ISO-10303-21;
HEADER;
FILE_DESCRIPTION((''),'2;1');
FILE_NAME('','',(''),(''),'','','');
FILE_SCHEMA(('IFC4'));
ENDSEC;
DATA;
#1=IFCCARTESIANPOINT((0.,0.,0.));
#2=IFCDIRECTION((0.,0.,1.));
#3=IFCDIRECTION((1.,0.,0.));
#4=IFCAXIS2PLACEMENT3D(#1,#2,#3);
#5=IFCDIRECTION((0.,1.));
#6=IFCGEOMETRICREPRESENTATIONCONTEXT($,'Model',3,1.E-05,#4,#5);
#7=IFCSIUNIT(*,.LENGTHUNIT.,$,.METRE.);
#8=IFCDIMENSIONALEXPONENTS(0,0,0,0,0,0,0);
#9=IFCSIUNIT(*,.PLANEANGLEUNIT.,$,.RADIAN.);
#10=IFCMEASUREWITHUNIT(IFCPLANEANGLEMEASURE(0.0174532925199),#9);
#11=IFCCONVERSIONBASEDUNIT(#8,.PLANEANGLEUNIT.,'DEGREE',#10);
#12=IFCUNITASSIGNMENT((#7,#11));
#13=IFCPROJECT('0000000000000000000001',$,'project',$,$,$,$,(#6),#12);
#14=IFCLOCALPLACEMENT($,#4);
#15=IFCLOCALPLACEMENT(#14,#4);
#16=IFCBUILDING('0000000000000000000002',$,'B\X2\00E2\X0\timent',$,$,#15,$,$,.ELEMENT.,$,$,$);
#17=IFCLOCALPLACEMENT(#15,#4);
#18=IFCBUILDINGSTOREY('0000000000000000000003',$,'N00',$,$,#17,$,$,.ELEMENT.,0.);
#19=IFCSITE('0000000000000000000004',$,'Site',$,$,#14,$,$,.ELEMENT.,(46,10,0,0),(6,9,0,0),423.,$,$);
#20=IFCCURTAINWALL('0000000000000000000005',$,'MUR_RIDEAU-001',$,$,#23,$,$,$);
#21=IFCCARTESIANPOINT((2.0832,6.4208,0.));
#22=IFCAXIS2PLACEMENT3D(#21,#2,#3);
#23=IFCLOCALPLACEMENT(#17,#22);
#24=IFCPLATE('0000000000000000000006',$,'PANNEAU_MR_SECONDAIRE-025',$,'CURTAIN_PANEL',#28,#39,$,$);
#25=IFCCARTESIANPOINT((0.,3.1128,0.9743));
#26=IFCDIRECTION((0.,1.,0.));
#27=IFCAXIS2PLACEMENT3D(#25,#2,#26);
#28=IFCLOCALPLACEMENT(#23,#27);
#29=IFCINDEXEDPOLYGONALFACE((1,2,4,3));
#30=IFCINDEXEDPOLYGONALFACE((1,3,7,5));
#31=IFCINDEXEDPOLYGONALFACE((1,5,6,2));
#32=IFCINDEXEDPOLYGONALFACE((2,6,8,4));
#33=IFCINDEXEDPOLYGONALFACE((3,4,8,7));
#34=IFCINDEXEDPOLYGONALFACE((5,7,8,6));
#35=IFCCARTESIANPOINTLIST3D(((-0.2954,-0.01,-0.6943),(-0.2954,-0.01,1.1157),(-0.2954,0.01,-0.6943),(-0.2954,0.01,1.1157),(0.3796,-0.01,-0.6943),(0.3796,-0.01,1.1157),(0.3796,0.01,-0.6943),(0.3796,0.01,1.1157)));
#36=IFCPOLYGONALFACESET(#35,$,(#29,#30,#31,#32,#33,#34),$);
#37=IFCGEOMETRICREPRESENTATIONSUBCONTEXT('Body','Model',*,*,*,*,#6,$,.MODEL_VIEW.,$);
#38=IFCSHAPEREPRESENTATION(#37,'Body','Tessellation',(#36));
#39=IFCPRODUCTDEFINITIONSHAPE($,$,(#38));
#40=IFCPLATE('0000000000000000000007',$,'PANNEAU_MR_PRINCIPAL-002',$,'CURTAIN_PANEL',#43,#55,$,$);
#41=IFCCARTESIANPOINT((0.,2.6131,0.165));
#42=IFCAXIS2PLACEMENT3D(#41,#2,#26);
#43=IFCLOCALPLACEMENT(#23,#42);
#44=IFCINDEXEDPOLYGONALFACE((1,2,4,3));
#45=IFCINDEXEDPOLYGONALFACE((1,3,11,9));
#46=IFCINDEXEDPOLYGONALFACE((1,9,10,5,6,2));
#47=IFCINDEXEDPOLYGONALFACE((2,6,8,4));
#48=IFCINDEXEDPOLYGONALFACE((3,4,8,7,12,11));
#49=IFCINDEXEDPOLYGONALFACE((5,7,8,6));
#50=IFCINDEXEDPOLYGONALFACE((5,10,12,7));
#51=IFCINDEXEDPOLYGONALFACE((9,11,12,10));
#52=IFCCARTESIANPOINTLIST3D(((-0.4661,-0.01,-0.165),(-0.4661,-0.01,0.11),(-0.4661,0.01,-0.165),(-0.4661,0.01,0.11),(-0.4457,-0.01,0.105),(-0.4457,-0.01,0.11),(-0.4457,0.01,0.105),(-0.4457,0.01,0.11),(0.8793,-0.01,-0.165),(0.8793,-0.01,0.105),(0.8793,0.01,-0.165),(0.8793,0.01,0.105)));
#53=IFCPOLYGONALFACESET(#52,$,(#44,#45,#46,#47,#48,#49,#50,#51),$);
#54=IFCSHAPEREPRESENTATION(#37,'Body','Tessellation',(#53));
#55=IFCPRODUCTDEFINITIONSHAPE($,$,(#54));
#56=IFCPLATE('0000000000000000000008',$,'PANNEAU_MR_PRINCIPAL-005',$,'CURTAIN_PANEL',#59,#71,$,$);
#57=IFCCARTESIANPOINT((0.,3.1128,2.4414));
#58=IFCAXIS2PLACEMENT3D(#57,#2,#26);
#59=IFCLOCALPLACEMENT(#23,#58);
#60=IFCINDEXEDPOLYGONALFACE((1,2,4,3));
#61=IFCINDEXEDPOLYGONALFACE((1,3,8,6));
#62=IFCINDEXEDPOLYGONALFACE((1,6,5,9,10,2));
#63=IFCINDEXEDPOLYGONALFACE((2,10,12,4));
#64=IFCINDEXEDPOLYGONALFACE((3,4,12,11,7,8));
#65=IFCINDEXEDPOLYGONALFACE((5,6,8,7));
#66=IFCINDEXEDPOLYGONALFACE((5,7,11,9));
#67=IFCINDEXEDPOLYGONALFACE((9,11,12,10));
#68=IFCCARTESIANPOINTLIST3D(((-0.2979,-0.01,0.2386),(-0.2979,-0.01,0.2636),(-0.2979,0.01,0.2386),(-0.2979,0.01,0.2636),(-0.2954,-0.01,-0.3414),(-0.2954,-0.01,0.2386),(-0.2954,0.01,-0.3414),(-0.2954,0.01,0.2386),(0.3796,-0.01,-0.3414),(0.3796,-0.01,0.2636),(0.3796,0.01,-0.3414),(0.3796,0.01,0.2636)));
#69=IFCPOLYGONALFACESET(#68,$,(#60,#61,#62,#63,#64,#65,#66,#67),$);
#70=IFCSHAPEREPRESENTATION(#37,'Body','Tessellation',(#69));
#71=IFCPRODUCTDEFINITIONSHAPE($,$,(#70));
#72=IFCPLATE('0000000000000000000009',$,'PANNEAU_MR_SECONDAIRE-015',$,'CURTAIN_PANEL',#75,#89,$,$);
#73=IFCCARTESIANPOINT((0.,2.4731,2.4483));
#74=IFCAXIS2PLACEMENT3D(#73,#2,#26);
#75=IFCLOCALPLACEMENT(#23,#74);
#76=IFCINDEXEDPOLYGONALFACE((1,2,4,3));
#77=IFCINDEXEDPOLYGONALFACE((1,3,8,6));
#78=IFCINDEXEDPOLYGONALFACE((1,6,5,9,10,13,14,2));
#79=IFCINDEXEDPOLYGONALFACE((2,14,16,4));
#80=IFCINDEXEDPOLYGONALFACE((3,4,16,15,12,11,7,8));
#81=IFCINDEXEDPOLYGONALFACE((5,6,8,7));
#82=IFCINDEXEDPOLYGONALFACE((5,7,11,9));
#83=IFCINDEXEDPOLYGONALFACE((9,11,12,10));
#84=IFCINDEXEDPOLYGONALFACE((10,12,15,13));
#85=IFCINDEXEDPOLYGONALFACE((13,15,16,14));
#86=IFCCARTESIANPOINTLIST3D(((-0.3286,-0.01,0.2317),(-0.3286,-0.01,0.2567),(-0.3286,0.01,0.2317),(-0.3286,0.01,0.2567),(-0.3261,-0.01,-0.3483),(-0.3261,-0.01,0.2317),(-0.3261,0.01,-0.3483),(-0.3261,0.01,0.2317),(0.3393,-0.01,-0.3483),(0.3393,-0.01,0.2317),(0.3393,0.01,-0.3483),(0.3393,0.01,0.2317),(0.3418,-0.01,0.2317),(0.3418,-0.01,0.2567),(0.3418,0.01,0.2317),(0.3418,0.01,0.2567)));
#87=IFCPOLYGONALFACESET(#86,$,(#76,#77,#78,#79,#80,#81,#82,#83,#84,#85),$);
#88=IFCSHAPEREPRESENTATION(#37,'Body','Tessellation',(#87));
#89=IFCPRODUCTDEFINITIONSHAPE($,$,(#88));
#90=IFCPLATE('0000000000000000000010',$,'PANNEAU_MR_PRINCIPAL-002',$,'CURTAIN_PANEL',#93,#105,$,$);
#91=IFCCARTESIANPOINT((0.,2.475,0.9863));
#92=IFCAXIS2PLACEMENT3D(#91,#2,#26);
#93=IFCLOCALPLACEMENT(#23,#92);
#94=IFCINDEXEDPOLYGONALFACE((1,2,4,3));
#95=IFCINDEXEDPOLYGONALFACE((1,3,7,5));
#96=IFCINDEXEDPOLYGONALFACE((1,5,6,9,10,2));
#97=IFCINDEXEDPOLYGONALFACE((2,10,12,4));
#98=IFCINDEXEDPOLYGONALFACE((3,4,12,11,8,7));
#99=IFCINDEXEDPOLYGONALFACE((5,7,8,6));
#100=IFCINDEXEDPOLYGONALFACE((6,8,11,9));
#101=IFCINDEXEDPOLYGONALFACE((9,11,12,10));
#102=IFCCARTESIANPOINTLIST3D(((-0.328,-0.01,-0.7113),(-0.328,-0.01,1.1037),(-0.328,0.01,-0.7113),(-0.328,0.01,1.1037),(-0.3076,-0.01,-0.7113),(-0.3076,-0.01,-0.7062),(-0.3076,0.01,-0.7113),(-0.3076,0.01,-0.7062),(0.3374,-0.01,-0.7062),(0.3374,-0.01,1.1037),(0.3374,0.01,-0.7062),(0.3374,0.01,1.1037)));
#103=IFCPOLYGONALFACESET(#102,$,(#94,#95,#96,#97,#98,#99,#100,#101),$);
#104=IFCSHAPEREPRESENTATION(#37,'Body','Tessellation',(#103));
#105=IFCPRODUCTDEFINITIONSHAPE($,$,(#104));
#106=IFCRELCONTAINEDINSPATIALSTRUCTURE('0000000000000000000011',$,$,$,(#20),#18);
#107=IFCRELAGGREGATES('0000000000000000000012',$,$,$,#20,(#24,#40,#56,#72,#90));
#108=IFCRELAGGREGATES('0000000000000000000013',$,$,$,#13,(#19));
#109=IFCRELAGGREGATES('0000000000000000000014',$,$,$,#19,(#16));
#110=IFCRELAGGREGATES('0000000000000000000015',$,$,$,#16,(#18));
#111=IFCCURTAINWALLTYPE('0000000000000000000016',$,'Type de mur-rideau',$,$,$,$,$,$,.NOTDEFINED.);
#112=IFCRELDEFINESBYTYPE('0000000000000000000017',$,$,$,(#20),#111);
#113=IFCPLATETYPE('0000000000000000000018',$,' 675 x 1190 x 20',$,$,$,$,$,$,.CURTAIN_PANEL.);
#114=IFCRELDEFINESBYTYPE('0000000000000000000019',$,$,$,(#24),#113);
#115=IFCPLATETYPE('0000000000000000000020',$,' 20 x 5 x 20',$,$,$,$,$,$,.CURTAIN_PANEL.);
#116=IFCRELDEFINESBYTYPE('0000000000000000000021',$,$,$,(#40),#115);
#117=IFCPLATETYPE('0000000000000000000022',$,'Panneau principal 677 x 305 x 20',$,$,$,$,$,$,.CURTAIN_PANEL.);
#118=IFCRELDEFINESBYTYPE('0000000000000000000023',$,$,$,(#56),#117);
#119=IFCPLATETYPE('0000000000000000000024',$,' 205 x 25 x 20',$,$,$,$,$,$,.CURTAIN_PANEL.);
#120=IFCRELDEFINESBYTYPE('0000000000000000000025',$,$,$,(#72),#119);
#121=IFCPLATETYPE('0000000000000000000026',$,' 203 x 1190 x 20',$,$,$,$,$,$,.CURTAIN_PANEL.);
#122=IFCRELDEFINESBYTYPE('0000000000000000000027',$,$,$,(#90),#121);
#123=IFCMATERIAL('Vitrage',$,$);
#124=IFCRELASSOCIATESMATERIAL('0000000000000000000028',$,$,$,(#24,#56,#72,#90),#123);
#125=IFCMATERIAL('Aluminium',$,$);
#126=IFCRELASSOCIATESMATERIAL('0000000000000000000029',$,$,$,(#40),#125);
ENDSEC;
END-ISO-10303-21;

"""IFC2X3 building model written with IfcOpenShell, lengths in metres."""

from ifc_helpers import new_model, entity, si_unit, converted_unit, direction, frame, origin_with_axes, place, context, subcontext, project, spatial, polyline, outline, extrude, material, type_object, element, aggregate, save


model = new_model("IFC2X3")

# Units and contexts
model_context = context("Model", 3, precision=1e-05, world=origin_with_axes(), true_north=direction((0.0, 1.0)))
body_context = subcontext(model_context, "Body", "Model", "MODEL_VIEW")
ifc_project = project(units=[si_unit("LENGTHUNIT", "METRE"), converted_unit("PLANEANGLEUNIT", "DEGREE", entity("IfcPlaneAngleMeasure", 0.0174532925199), si_unit("PLANEANGLEUNIT", "RADIAN"), dimensions=[0, 0, 0, 0, 0, 0, 0])], contexts=[model_context])

# Site, building, storey
site_placement = place(None, origin_with_axes())
site = spatial("IfcSite", under=ifc_project, at=site_placement, Name="Site", CompositionType="ELEMENT", RefLatitude=(46, 10, 0, 0), RefLongitude=(6, 9, 0, 0), RefElevation=423.0)
building_placement = place(site_placement, origin_with_axes())
building = spatial("IfcBuilding", under=site, at=building_placement, Name="Bâtiment", CompositionType="ELEMENT")
storey_placement = place(building_placement, origin_with_axes())
storey = spatial("IfcBuildingStorey", under=building, at=storey_placement, Name="N00", CompositionType="ELEMENT", Elevation=0.0)

# Curtain wall, plates
curtain_wall_type = type_object("IfcCurtainWallType", Name="Type de mur-rideau", PredefinedType="NOTDEFINED")
curtain_wall_placement = place(storey_placement, frame((2.0832, 6.4208, 0.0), z_axis=(0.0, 0.0, 1.0), x_axis=(1.0, 0.0, 0.0)))
curtain_wall = element("IfcCurtainWall", 1, at=curtain_wall_placement, inside=storey, type_object=curtain_wall_type, Name="MUR_RIDEAU-001")
ifc_material_1 = material(Name="Aluminium")
ifc_material_2 = material(Name="Vitrage")
plate_type_1 = type_object("IfcPlateType", Name=" 675 x 1190 x 20", PredefinedType="CURTAIN_PANEL")
plate_1_placement = place(curtain_wall_placement, frame((0.0, 3.1128, 0.9743), z_axis=(0.0, 0.0, 1.0), x_axis=(0.0, 1.0, 0.0)))
plate_1 = element("IfcPlate", 2, at=plate_1_placement, type_object=plate_type_1, material=ifc_material_2, Name="PANNEAU_MR_SECONDAIRE-025", ObjectType="CURTAIN_PANEL", context=body_context, shape_type="SweptSolid", body=[
    extrude(outline(polyline([(-0.2954, -1.1157), (0.3796, -1.1157), (0.3796, 0.6943), (-0.2954, 0.6943), (-0.2954, -1.1157)])), frame((0.0, -0.01, 0.0), z_axis=(0.0, 1.0, 0.0), x_axis=(1.0, 0.0, 0.0)), (0.0, 0.0, 1.0), 0.02),
])
plate_type_2 = type_object("IfcPlateType", Name=" 20 x 5 x 20", PredefinedType="CURTAIN_PANEL")
plate_2_placement = place(curtain_wall_placement, frame((0.0, 2.6131, 0.165), z_axis=(0.0, 0.0, 1.0), x_axis=(0.0, 1.0, 0.0)))
plate_2 = element("IfcPlate", 3, at=plate_2_placement, type_object=plate_type_2, material=ifc_material_1, Name="PANNEAU_MR_PRINCIPAL-002", ObjectType="CURTAIN_PANEL", context=body_context, shape_type="SweptSolid", body=[
    extrude(outline(polyline([(-0.4661, -0.11), (-0.4457, -0.11), (-0.4457, -0.105), (0.8793, -0.105), (0.8793, 0.165), (-0.4661, 0.165), (-0.4661, -0.11)])), frame((0.0, -0.01, 0.0), z_axis=(0.0, 1.0, 0.0), x_axis=(1.0, 0.0, 0.0)), (0.0, 0.0, 1.0), 0.02),
])
plate_type_3 = type_object("IfcPlateType", Name="Panneau principal 677 x 305 x 20", PredefinedType="CURTAIN_PANEL")
plate_3_placement = place(curtain_wall_placement, frame((0.0, 3.1128, 2.4414), z_axis=(0.0, 0.0, 1.0), x_axis=(0.0, 1.0, 0.0)))
plate_3 = element("IfcPlate", 4, at=plate_3_placement, type_object=plate_type_3, material=ifc_material_2, Name="PANNEAU_MR_PRINCIPAL-005", ObjectType="CURTAIN_PANEL", context=body_context, shape_type="SweptSolid", body=[
    extrude(outline(polyline([(-0.2979, -0.2636), (0.3796, -0.2636), (0.3796, 0.3414), (-0.2954, 0.3414), (-0.2954, -0.2386), (-0.2979, -0.2386), (-0.2979, -0.2636)])), frame((0.0, -0.01, 0.0), z_axis=(0.0, 1.0, 0.0), x_axis=(1.0, 0.0, 0.0)), (0.0, 0.0, 1.0), 0.02),
])
plate_type_4 = type_object("IfcPlateType", Name=" 205 x 25 x 20", PredefinedType="CURTAIN_PANEL")
plate_4_placement = place(curtain_wall_placement, frame((0.0, 2.4731, 2.4483), z_axis=(0.0, 0.0, 1.0), x_axis=(0.0, 1.0, 0.0)))
plate_4 = element("IfcPlate", 5, at=plate_4_placement, type_object=plate_type_4, material=ifc_material_2, Name="PANNEAU_MR_SECONDAIRE-015", ObjectType="CURTAIN_PANEL", context=body_context, shape_type="SweptSolid", body=[
    extrude(outline(polyline([(-0.3286, -0.2567), (0.3418, -0.2567), (0.3418, -0.2317), (0.3393, -0.2317), (0.3393, 0.3483), (-0.3261, 0.3483), (-0.3261, -0.2317), (-0.3286, -0.2317), (-0.3286, -0.2567)])), frame((0.0, -0.01, 0.0), z_axis=(0.0, 1.0, 0.0), x_axis=(1.0, 0.0, 0.0)), (0.0, 0.0, 1.0), 0.02),
])
plate_type_5 = type_object("IfcPlateType", Name=" 203 x 1190 x 20", PredefinedType="CURTAIN_PANEL")
plate_5_placement = place(curtain_wall_placement, frame((0.0, 2.475, 0.9863), z_axis=(0.0, 0.0, 1.0), x_axis=(0.0, 1.0, 0.0)))
plate_5 = element("IfcPlate", 6, at=plate_5_placement, type_object=plate_type_5, material=ifc_material_2, Name="PANNEAU_MR_PRINCIPAL-002", ObjectType="CURTAIN_PANEL", context=body_context, shape_type="SweptSolid", body=[
    extrude(outline(polyline([(-0.328, -1.1037), (0.3374, -1.1037), (0.3374, 0.7062), (-0.3076, 0.7062), (-0.3076, 0.7113), (-0.328, 0.7113), (-0.328, -1.1037)])), frame((0.0, -0.01, 0.0), z_axis=(0.0, 1.0, 0.0), x_axis=(1.0, 0.0, 0.0)), (0.0, 0.0, 1.0), 0.02),
])
aggregate(curtain_wall, [plate_1, plate_2, plate_3, plate_4, plate_5])

save(model, "model.ifc")
